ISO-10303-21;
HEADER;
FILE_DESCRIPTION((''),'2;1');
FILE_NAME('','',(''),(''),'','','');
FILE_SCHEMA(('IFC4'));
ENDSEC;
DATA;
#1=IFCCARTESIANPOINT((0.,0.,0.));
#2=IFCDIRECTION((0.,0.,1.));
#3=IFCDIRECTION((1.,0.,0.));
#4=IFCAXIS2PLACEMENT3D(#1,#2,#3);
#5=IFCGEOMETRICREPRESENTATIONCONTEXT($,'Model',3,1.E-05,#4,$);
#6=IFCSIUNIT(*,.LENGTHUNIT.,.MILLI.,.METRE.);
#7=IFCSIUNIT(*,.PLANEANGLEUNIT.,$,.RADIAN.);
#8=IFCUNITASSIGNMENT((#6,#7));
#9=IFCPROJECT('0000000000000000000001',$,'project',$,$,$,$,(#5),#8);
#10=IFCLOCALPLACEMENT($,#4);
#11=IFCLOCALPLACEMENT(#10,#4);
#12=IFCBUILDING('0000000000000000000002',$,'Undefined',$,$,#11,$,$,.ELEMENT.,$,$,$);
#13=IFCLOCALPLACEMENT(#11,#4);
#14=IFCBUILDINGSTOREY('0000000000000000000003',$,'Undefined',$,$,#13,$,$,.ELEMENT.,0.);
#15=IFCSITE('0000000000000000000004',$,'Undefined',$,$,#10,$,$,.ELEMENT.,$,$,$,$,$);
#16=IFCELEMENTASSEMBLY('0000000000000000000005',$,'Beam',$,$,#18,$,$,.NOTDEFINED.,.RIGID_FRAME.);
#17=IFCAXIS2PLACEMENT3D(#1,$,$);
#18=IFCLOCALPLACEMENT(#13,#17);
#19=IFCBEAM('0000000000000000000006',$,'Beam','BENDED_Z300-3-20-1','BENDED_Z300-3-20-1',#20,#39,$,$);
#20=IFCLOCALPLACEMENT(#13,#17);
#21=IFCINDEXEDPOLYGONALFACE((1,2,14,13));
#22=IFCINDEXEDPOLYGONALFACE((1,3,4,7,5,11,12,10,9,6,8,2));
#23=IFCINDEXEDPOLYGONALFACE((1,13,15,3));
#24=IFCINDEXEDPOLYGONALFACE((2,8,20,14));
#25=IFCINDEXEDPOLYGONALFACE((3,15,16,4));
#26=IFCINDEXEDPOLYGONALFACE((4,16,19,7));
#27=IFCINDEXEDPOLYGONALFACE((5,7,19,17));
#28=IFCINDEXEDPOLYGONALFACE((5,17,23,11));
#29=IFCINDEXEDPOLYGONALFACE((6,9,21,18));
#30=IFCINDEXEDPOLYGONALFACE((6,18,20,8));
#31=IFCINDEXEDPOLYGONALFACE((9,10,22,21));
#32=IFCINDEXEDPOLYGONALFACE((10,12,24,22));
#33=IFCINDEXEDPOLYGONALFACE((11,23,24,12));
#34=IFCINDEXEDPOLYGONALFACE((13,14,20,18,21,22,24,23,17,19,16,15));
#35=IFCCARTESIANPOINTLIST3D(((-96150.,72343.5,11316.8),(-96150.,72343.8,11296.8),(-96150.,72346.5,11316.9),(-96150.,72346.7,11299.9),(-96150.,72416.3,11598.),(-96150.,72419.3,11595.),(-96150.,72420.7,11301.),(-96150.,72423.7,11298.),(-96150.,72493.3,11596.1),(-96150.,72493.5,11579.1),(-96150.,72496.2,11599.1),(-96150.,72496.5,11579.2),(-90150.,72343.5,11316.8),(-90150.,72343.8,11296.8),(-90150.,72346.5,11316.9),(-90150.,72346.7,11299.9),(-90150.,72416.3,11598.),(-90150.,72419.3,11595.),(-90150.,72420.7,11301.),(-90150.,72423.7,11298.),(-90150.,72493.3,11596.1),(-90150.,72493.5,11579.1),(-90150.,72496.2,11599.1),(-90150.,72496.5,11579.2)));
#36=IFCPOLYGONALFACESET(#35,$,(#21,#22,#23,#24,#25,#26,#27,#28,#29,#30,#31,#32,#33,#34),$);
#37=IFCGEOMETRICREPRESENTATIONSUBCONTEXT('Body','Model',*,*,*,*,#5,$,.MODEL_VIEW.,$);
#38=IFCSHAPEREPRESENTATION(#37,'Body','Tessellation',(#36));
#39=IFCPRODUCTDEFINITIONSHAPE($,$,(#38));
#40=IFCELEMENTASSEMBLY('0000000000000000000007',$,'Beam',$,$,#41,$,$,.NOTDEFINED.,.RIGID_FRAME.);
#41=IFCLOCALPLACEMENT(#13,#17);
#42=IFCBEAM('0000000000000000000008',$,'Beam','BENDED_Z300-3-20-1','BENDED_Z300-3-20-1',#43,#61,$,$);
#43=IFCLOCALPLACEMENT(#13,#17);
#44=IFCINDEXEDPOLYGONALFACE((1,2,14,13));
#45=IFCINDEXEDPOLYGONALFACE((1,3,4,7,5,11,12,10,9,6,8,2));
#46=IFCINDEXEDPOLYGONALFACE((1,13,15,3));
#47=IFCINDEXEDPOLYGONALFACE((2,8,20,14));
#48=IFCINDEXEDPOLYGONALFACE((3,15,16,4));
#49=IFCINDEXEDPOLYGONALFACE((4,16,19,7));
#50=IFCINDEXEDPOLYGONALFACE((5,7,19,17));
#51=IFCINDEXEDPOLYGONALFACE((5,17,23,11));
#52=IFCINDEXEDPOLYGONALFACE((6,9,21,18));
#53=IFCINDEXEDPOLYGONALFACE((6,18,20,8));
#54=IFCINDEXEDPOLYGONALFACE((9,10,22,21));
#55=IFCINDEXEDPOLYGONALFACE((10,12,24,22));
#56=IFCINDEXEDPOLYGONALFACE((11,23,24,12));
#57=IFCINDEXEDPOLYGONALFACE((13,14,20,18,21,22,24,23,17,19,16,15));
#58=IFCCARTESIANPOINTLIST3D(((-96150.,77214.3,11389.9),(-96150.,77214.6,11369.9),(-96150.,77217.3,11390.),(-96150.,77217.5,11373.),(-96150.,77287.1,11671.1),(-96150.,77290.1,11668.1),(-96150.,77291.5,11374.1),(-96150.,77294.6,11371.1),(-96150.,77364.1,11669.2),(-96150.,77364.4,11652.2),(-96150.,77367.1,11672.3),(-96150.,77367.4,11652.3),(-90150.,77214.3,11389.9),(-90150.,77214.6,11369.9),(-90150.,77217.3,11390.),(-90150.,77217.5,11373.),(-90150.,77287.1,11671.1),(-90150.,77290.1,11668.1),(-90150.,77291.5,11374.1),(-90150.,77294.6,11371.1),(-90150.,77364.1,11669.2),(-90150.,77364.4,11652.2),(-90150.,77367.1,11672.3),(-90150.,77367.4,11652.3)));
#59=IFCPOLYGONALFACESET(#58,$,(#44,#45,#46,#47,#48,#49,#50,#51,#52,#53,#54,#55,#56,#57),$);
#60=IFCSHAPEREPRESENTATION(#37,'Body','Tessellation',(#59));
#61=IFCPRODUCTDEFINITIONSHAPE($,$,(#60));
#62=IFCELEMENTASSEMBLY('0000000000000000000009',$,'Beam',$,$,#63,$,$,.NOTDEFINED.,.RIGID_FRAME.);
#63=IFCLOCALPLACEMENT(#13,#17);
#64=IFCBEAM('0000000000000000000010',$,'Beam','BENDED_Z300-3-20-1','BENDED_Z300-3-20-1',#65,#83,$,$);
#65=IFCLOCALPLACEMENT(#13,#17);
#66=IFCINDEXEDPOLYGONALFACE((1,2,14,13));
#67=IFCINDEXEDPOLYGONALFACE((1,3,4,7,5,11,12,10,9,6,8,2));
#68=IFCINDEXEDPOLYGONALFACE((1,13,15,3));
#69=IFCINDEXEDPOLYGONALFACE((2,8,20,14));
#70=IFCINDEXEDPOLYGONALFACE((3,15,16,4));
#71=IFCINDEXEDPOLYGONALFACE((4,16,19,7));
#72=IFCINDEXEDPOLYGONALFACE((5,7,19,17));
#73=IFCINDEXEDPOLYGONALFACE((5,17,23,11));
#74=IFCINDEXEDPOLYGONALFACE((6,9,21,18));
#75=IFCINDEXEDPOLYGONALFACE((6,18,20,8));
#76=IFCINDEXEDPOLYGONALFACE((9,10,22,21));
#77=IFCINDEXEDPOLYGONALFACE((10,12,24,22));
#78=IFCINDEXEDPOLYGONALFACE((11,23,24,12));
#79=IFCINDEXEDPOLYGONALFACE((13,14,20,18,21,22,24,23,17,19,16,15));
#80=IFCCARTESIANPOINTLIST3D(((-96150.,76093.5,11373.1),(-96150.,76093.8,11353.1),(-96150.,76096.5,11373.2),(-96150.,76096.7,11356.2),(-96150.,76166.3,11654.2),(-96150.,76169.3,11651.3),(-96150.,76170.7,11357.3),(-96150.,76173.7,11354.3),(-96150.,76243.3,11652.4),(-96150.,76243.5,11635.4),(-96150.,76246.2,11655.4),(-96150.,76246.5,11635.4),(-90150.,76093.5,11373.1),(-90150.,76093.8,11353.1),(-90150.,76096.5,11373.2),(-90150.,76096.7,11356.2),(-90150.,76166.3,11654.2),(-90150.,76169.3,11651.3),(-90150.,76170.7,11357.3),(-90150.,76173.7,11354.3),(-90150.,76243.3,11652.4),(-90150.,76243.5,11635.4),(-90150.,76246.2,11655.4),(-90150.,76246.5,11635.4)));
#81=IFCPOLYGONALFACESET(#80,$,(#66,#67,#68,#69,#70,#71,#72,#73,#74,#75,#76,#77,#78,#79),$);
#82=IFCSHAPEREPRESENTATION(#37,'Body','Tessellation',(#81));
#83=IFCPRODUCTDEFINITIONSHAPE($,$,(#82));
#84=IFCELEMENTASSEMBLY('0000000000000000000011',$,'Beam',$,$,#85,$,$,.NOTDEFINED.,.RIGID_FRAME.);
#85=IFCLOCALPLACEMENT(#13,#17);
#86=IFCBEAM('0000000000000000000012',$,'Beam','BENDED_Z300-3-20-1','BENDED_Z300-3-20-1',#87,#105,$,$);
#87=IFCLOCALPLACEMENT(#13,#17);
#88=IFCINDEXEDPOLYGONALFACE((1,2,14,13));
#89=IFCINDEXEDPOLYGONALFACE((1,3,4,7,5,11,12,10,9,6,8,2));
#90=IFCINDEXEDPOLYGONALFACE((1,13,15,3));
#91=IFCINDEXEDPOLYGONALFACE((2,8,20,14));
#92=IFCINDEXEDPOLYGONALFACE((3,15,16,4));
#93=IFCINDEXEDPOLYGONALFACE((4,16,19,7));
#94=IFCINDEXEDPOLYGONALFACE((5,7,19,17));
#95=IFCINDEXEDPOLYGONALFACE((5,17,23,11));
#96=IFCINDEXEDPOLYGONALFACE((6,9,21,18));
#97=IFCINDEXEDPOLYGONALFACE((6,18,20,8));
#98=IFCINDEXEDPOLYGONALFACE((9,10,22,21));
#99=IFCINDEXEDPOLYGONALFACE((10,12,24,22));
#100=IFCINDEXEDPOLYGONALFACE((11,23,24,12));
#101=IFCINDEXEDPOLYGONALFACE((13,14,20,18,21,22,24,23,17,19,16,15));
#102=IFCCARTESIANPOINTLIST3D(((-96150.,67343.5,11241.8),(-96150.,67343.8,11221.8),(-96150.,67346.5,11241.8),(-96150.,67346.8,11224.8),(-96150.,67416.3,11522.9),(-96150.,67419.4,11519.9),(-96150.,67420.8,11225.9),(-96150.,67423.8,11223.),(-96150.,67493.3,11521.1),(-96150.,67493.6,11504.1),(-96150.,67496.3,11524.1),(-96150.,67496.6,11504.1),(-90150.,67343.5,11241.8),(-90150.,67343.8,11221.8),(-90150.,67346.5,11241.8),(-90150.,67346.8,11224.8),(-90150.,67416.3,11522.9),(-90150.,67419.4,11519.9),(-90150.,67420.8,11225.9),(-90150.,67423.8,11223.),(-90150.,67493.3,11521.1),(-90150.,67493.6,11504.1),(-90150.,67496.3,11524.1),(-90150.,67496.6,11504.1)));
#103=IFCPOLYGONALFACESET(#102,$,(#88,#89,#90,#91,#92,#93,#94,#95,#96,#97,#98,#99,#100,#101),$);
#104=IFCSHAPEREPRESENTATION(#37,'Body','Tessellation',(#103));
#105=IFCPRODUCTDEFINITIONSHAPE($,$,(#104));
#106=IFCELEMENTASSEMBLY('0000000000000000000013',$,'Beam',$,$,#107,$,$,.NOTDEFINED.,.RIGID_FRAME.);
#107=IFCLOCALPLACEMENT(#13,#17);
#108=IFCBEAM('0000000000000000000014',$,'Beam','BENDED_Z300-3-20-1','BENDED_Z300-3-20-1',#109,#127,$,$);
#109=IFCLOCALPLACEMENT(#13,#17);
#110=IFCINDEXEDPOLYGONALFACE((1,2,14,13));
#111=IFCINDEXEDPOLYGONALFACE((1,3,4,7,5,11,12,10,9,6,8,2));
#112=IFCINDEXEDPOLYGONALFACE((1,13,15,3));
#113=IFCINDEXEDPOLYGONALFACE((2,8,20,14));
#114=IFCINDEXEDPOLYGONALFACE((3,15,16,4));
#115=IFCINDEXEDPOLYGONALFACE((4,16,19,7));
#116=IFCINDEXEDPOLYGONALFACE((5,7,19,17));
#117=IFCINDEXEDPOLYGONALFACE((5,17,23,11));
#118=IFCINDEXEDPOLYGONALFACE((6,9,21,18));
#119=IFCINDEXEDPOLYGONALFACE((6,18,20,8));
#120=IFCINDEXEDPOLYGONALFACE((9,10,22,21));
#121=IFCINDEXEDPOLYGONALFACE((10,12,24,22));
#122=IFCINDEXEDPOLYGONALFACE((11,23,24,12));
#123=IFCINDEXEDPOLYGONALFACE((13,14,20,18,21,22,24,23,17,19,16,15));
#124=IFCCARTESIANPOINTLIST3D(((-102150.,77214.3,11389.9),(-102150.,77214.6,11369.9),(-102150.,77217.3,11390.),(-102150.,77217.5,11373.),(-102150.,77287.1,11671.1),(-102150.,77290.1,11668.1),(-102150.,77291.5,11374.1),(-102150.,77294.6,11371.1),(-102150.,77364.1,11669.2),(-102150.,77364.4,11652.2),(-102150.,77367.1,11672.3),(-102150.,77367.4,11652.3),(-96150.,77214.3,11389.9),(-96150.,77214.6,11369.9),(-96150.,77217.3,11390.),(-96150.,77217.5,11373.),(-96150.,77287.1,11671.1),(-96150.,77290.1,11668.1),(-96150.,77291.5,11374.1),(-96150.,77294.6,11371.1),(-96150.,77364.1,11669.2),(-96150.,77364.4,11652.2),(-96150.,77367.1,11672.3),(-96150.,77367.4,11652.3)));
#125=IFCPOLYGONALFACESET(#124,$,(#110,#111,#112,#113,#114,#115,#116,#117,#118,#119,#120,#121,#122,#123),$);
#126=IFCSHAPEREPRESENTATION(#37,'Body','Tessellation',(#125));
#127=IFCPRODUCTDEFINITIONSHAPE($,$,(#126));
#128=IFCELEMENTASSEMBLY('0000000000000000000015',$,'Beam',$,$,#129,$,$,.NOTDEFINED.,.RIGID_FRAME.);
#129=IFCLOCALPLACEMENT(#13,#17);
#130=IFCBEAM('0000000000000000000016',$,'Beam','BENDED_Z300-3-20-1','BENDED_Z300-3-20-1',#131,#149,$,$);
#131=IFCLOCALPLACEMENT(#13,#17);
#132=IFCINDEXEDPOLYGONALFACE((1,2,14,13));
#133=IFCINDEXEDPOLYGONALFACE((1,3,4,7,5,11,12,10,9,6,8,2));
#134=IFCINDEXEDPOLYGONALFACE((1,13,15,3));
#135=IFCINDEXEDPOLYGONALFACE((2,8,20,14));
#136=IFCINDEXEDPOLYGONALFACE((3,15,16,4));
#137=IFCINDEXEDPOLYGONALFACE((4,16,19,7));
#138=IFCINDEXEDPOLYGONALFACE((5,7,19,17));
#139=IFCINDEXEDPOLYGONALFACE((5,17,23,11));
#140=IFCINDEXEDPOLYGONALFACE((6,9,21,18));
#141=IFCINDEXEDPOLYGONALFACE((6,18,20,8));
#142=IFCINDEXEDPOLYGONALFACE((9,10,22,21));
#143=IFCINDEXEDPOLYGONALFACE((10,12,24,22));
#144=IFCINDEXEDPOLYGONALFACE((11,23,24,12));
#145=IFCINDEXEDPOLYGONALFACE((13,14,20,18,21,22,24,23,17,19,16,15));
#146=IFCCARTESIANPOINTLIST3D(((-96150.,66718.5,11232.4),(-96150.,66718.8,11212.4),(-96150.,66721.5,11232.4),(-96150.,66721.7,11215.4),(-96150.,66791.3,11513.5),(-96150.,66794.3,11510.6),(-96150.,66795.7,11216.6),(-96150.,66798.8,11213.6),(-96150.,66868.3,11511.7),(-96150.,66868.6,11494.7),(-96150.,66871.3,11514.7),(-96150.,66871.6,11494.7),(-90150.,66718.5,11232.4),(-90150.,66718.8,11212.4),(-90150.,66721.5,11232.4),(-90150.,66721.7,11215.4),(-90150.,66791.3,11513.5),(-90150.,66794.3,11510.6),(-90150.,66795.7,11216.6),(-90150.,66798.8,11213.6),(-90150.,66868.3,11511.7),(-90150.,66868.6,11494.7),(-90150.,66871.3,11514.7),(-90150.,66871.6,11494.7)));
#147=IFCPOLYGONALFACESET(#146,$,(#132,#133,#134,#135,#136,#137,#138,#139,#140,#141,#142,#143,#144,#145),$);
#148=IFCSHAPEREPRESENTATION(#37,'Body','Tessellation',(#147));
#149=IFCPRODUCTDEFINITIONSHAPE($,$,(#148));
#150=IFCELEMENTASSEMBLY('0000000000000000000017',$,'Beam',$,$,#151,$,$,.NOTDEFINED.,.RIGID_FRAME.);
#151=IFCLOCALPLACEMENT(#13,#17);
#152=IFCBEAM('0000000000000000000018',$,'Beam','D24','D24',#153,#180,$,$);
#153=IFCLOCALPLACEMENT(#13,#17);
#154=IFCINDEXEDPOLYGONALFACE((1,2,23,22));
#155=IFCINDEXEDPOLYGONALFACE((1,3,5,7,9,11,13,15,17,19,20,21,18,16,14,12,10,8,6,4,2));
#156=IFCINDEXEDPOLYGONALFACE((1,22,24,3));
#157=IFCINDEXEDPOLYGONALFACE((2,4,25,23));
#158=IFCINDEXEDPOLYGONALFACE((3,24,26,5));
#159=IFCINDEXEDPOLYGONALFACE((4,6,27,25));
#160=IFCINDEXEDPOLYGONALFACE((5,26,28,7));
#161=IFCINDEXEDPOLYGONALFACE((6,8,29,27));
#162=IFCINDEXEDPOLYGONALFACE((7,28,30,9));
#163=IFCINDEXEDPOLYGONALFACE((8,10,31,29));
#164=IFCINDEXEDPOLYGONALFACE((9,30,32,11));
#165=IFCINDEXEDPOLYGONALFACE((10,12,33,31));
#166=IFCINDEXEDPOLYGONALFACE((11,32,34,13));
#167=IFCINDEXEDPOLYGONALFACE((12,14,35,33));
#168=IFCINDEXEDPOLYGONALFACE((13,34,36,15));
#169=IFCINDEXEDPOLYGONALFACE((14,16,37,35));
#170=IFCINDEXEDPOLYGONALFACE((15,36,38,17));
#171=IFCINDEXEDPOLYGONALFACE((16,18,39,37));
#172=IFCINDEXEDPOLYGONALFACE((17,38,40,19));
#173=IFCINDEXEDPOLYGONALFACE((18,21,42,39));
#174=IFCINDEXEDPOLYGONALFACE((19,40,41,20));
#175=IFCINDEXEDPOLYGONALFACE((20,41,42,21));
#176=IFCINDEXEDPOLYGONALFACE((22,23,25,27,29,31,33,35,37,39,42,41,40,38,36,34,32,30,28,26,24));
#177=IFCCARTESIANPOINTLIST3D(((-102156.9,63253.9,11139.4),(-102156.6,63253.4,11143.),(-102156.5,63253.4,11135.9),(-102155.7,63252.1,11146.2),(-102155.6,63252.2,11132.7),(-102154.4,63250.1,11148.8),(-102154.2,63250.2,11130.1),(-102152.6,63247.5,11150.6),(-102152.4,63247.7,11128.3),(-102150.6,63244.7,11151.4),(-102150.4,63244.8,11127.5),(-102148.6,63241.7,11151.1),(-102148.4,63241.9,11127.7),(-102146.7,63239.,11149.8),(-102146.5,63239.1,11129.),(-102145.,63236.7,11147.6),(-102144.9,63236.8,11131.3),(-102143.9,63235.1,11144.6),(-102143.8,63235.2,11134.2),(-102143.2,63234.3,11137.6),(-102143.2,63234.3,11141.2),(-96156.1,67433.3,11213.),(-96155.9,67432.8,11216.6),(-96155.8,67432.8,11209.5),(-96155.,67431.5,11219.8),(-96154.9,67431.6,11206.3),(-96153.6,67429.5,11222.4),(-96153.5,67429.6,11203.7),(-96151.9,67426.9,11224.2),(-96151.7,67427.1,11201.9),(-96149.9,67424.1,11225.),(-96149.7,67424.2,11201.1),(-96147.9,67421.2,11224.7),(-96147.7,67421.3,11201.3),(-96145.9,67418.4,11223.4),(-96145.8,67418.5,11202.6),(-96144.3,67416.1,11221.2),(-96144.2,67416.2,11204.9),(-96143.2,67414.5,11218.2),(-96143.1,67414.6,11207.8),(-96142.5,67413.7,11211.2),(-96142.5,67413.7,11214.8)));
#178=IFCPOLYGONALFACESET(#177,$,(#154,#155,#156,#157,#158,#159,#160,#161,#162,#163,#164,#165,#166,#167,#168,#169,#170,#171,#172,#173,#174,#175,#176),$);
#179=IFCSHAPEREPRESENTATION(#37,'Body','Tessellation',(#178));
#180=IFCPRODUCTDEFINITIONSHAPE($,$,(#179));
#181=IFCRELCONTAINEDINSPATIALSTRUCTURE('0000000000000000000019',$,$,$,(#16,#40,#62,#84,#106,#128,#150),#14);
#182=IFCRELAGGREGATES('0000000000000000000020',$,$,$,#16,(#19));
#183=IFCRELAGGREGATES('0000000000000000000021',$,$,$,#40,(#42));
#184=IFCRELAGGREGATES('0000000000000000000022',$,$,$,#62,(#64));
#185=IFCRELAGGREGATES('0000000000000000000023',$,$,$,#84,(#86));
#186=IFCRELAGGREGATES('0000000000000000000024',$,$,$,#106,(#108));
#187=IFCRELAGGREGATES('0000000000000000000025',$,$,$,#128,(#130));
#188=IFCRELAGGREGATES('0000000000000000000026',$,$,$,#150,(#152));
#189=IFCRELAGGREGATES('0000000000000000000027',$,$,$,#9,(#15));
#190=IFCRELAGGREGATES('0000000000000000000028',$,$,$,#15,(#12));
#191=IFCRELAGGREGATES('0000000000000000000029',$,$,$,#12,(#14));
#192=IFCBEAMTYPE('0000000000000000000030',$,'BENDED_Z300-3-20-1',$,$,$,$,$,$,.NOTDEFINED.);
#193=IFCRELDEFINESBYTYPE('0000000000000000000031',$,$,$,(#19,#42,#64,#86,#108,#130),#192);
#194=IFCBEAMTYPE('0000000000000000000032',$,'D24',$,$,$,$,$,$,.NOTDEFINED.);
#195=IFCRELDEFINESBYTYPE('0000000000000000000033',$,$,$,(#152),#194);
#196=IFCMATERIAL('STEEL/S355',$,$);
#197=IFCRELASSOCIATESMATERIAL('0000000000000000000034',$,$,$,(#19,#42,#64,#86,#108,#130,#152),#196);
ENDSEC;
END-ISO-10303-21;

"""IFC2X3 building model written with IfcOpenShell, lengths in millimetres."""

from ifc_helpers import new_model, si_unit, frame, origin_with_axes, origin_2d_with_axis, place, context, subcontext, project, spatial, polyline, circle, outline, extrude, material, type_object, element, aggregate, save


model = new_model("IFC2X3")

# Units and contexts
model_context = context("Model", 3, precision=1e-05, world=origin_with_axes())
body_context = subcontext(model_context, "Body", "Model", "MODEL_VIEW")
ifc_project = project(units=[si_unit("LENGTHUNIT", "METRE", prefix="MILLI"), si_unit("PLANEANGLEUNIT", "RADIAN")], contexts=[model_context])

# Site, building, storey
site_placement = place(None, origin_with_axes())
site = spatial("IfcSite", under=ifc_project, at=site_placement, Name="Undefined", CompositionType="ELEMENT")
building_placement = place(site_placement, origin_with_axes())
building = spatial("IfcBuilding", under=site, at=building_placement, Name="Undefined", CompositionType="ELEMENT")
storey_placement = place(building_placement, origin_with_axes())
storey = spatial("IfcBuildingStorey", under=building, at=storey_placement, Name="Undefined", CompositionType="ELEMENT", Elevation=0.0)

# Element assemblies, beams
ifc_material = material(Name="STEEL/S355")
beam_type_1 = type_object("IfcBeamType", Name="BENDED_Z300-3-20-1", PredefinedType="NOTDEFINED")
assembly_1_placement = place(storey_placement, origin_with_axes())
assembly_1 = element("IfcElementAssembly", 1, at=assembly_1_placement, inside=storey, Name="Beam", AssemblyPlace="NOTDEFINED", PredefinedType="RIGID_FRAME")
beam_1_placement = place(assembly_1_placement, frame((-90150.0, 72420.0, 11448.0), z_axis=(0.0, -0.014963, 0.999888), x_axis=(-1.0, 0.0, 0.0)))
beam_1 = element("IfcBeam", 2, at=beam_1_placement, type_object=beam_type_1, material=ifc_material, Name="Beam", Description="BENDED_Z300-3-20-1", ObjectType="BENDED_Z300-3-20-1", context=body_context, shape_type="SweptSolid", body=[
    extrude(outline(polyline([(1.5, -150.0), (-78.5, -150.0), (-78.5, -130.0), (-75.5, -130.0), (-75.5, -147.0), (-1.5, -147.0), (-1.5, 150.0), (78.5, 150.0), (78.5, 130.0), (75.5, 130.0), (75.5, 147.0), (1.5, 147.0), (1.5, -150.0)])), frame((6000.0, 0.0, 0.0), z_axis=(-1.0, 0.0, 0.0), x_axis=(0.0, -1.0, 0.0)), (0.0, 0.0, 1.0), 6000.0),
])
aggregate(assembly_1, [beam_1])
assembly_2_placement = place(storey_placement, origin_with_axes())
assembly_2 = element("IfcElementAssembly", 3, at=assembly_2_placement, inside=storey, Name="Beam", AssemblyPlace="NOTDEFINED", PredefinedType="RIGID_FRAME")
beam_2_placement = place(assembly_2_placement, frame((-90150.0, 77290.8, 11521.1), z_axis=(0.0, -0.014963, 0.999888), x_axis=(-1.0, 0.0, 0.0)))
beam_2 = element("IfcBeam", 4, at=beam_2_placement, type_object=beam_type_1, material=ifc_material, Name="Beam", Description="BENDED_Z300-3-20-1", ObjectType="BENDED_Z300-3-20-1", context=body_context, shape_type="SweptSolid", body=[
    extrude(outline(polyline([(1.5, -150.0), (-78.5, -150.0), (-78.5, -130.0), (-75.5, -130.0), (-75.5, -147.0), (-1.5, -147.0), (-1.5, 150.0), (78.5, 150.0), (78.5, 130.0), (75.5, 130.0), (75.5, 147.0), (1.5, 147.0), (1.5, -150.0)])), frame((6000.0, 0.0, 0.0), z_axis=(-1.0, 0.0, 0.0), x_axis=(0.0, -1.0, 0.0)), (0.0, 0.0, 1.0), 6000.0),
])
aggregate(assembly_2, [beam_2])
assembly_3_placement = place(storey_placement, origin_with_axes())
assembly_3 = element("IfcElementAssembly", 5, at=assembly_3_placement, inside=storey, Name="Beam", AssemblyPlace="NOTDEFINED", PredefinedType="RIGID_FRAME")
beam_3_placement = place(assembly_3_placement, frame((-90150.0, 76170.0, 11504.3), z_axis=(0.0, -0.014963, 0.999888), x_axis=(-1.0, 0.0, 0.0)))
beam_3 = element("IfcBeam", 6, at=beam_3_placement, type_object=beam_type_1, material=ifc_material, Name="Beam", Description="BENDED_Z300-3-20-1", ObjectType="BENDED_Z300-3-20-1", context=body_context, shape_type="SweptSolid", body=[
    extrude(outline(polyline([(1.5, -150.0), (-78.5, -150.0), (-78.5, -130.0), (-75.5, -130.0), (-75.5, -147.0), (-1.5, -147.0), (-1.5, 150.0), (78.5, 150.0), (78.5, 130.0), (75.5, 130.0), (75.5, 147.0), (1.5, 147.0), (1.5, -150.0)])), frame((6000.0, 0.0, 0.0), z_axis=(-1.0, 0.0, 0.0), x_axis=(0.0, -1.0, 0.0)), (0.0, 0.0, 1.0), 6000.0),
])
aggregate(assembly_3, [beam_3])
assembly_4_placement = place(storey_placement, origin_with_axes())
assembly_4 = element("IfcElementAssembly", 7, at=assembly_4_placement, inside=storey, Name="Beam", AssemblyPlace="NOTDEFINED", PredefinedType="RIGID_FRAME")
beam_4_placement = place(assembly_4_placement, frame((-90150.0, 67420.1, 11372.9), z_axis=(0.0, -0.014963, 0.999888), x_axis=(-1.0, 0.0, 0.0)))
beam_4 = element("IfcBeam", 8, at=beam_4_placement, type_object=beam_type_1, material=ifc_material, Name="Beam", Description="BENDED_Z300-3-20-1", ObjectType="BENDED_Z300-3-20-1", context=body_context, shape_type="SweptSolid", body=[
    extrude(outline(polyline([(1.5, -150.0), (-78.5, -150.0), (-78.5, -130.0), (-75.5, -130.0), (-75.5, -147.0), (-1.5, -147.0), (-1.5, 150.0), (78.5, 150.0), (78.5, 130.0), (75.5, 130.0), (75.5, 147.0), (1.5, 147.0), (1.5, -150.0)])), frame((6000.0, 0.0, 0.0), z_axis=(-1.0, 0.0, 0.0), x_axis=(0.0, -1.0, 0.0)), (0.0, 0.0, 1.0), 6000.0),
])
aggregate(assembly_4, [beam_4])
assembly_5_placement = place(storey_placement, origin_with_axes())
assembly_5 = element("IfcElementAssembly", 9, at=assembly_5_placement, inside=storey, Name="Beam", AssemblyPlace="NOTDEFINED", PredefinedType="RIGID_FRAME")
beam_5_placement = place(assembly_5_placement, frame((-96150.0, 77290.8, 11521.1), z_axis=(0.0, -0.014963, 0.999888), x_axis=(-1.0, 0.0, 0.0)))
beam_5 = element("IfcBeam", 10, at=beam_5_placement, type_object=beam_type_1, material=ifc_material, Name="Beam", Description="BENDED_Z300-3-20-1", ObjectType="BENDED_Z300-3-20-1", context=body_context, shape_type="SweptSolid", body=[
    extrude(outline(polyline([(1.5, -150.0), (-78.5, -150.0), (-78.5, -130.0), (-75.5, -130.0), (-75.5, -147.0), (-1.5, -147.0), (-1.5, 150.0), (78.5, 150.0), (78.5, 130.0), (75.5, 130.0), (75.5, 147.0), (1.5, 147.0), (1.5, -150.0)])), frame((6000.0, 0.0, 0.0), z_axis=(-1.0, 0.0, 0.0), x_axis=(0.0, -1.0, 0.0)), (0.0, 0.0, 1.0), 6000.0),
])
aggregate(assembly_5, [beam_5])
assembly_6_placement = place(storey_placement, origin_with_axes())
assembly_6 = element("IfcElementAssembly", 11, at=assembly_6_placement, inside=storey, Name="Beam", AssemblyPlace="NOTDEFINED", PredefinedType="RIGID_FRAME")
beam_6_placement = place(assembly_6_placement, frame((-90150.0, 66795.0, 11363.6), z_axis=(0.0, -0.014963, 0.999888), x_axis=(-1.0, 0.0, 0.0)))
beam_6 = element("IfcBeam", 12, at=beam_6_placement, type_object=beam_type_1, material=ifc_material, Name="Beam", Description="BENDED_Z300-3-20-1", ObjectType="BENDED_Z300-3-20-1", context=body_context, shape_type="SweptSolid", body=[
    extrude(outline(polyline([(1.5, -150.0), (-78.5, -150.0), (-78.5, -130.0), (-75.5, -130.0), (-75.5, -147.0), (-1.5, -147.0), (-1.5, 150.0), (78.5, 150.0), (78.5, 130.0), (75.5, 130.0), (75.5, 147.0), (1.5, 147.0), (1.5, -150.0)])), frame((6000.0, 0.0, 0.0), z_axis=(-1.0, 0.0, 0.0), x_axis=(0.0, -1.0, 0.0)), (0.0, 0.0, 1.0), 6000.0),
])
aggregate(assembly_6, [beam_6])
assembly_7_placement = place(storey_placement, origin_with_axes())
assembly_7 = element("IfcElementAssembly", 13, at=assembly_7_placement, inside=storey, Name="Beam", AssemblyPlace="NOTDEFINED", PredefinedType="RIGID_FRAME")
beam_type_2 = type_object("IfcBeamType", Name="D24", PredefinedType="NOTDEFINED")
beam_7_placement = place(assembly_7_placement, frame((-96149.3, 67423.4, 11213.0), z_axis=(-0.008259, -0.005752, 0.999949), x_axis=(-0.820543, -0.571496, -0.010064)))
beam_7 = element("IfcBeam", 14, at=beam_7_placement, type_object=beam_type_2, material=ifc_material, Name="Beam", Description="D24", ObjectType="D24", context=body_context, shape_type="SweptSolid", body=[
    extrude(circle(Radius=12.0, at=origin_2d_with_axis()), frame((7313.1, 0.0, 0.0), z_axis=(-1.0, 0.0, 0.0), x_axis=(0.0, -1.0, 0.0)), (0.0, 0.0, 1.0), 7313.1),
])
aggregate(assembly_7, [beam_7])

save(model, "model.ifc")
